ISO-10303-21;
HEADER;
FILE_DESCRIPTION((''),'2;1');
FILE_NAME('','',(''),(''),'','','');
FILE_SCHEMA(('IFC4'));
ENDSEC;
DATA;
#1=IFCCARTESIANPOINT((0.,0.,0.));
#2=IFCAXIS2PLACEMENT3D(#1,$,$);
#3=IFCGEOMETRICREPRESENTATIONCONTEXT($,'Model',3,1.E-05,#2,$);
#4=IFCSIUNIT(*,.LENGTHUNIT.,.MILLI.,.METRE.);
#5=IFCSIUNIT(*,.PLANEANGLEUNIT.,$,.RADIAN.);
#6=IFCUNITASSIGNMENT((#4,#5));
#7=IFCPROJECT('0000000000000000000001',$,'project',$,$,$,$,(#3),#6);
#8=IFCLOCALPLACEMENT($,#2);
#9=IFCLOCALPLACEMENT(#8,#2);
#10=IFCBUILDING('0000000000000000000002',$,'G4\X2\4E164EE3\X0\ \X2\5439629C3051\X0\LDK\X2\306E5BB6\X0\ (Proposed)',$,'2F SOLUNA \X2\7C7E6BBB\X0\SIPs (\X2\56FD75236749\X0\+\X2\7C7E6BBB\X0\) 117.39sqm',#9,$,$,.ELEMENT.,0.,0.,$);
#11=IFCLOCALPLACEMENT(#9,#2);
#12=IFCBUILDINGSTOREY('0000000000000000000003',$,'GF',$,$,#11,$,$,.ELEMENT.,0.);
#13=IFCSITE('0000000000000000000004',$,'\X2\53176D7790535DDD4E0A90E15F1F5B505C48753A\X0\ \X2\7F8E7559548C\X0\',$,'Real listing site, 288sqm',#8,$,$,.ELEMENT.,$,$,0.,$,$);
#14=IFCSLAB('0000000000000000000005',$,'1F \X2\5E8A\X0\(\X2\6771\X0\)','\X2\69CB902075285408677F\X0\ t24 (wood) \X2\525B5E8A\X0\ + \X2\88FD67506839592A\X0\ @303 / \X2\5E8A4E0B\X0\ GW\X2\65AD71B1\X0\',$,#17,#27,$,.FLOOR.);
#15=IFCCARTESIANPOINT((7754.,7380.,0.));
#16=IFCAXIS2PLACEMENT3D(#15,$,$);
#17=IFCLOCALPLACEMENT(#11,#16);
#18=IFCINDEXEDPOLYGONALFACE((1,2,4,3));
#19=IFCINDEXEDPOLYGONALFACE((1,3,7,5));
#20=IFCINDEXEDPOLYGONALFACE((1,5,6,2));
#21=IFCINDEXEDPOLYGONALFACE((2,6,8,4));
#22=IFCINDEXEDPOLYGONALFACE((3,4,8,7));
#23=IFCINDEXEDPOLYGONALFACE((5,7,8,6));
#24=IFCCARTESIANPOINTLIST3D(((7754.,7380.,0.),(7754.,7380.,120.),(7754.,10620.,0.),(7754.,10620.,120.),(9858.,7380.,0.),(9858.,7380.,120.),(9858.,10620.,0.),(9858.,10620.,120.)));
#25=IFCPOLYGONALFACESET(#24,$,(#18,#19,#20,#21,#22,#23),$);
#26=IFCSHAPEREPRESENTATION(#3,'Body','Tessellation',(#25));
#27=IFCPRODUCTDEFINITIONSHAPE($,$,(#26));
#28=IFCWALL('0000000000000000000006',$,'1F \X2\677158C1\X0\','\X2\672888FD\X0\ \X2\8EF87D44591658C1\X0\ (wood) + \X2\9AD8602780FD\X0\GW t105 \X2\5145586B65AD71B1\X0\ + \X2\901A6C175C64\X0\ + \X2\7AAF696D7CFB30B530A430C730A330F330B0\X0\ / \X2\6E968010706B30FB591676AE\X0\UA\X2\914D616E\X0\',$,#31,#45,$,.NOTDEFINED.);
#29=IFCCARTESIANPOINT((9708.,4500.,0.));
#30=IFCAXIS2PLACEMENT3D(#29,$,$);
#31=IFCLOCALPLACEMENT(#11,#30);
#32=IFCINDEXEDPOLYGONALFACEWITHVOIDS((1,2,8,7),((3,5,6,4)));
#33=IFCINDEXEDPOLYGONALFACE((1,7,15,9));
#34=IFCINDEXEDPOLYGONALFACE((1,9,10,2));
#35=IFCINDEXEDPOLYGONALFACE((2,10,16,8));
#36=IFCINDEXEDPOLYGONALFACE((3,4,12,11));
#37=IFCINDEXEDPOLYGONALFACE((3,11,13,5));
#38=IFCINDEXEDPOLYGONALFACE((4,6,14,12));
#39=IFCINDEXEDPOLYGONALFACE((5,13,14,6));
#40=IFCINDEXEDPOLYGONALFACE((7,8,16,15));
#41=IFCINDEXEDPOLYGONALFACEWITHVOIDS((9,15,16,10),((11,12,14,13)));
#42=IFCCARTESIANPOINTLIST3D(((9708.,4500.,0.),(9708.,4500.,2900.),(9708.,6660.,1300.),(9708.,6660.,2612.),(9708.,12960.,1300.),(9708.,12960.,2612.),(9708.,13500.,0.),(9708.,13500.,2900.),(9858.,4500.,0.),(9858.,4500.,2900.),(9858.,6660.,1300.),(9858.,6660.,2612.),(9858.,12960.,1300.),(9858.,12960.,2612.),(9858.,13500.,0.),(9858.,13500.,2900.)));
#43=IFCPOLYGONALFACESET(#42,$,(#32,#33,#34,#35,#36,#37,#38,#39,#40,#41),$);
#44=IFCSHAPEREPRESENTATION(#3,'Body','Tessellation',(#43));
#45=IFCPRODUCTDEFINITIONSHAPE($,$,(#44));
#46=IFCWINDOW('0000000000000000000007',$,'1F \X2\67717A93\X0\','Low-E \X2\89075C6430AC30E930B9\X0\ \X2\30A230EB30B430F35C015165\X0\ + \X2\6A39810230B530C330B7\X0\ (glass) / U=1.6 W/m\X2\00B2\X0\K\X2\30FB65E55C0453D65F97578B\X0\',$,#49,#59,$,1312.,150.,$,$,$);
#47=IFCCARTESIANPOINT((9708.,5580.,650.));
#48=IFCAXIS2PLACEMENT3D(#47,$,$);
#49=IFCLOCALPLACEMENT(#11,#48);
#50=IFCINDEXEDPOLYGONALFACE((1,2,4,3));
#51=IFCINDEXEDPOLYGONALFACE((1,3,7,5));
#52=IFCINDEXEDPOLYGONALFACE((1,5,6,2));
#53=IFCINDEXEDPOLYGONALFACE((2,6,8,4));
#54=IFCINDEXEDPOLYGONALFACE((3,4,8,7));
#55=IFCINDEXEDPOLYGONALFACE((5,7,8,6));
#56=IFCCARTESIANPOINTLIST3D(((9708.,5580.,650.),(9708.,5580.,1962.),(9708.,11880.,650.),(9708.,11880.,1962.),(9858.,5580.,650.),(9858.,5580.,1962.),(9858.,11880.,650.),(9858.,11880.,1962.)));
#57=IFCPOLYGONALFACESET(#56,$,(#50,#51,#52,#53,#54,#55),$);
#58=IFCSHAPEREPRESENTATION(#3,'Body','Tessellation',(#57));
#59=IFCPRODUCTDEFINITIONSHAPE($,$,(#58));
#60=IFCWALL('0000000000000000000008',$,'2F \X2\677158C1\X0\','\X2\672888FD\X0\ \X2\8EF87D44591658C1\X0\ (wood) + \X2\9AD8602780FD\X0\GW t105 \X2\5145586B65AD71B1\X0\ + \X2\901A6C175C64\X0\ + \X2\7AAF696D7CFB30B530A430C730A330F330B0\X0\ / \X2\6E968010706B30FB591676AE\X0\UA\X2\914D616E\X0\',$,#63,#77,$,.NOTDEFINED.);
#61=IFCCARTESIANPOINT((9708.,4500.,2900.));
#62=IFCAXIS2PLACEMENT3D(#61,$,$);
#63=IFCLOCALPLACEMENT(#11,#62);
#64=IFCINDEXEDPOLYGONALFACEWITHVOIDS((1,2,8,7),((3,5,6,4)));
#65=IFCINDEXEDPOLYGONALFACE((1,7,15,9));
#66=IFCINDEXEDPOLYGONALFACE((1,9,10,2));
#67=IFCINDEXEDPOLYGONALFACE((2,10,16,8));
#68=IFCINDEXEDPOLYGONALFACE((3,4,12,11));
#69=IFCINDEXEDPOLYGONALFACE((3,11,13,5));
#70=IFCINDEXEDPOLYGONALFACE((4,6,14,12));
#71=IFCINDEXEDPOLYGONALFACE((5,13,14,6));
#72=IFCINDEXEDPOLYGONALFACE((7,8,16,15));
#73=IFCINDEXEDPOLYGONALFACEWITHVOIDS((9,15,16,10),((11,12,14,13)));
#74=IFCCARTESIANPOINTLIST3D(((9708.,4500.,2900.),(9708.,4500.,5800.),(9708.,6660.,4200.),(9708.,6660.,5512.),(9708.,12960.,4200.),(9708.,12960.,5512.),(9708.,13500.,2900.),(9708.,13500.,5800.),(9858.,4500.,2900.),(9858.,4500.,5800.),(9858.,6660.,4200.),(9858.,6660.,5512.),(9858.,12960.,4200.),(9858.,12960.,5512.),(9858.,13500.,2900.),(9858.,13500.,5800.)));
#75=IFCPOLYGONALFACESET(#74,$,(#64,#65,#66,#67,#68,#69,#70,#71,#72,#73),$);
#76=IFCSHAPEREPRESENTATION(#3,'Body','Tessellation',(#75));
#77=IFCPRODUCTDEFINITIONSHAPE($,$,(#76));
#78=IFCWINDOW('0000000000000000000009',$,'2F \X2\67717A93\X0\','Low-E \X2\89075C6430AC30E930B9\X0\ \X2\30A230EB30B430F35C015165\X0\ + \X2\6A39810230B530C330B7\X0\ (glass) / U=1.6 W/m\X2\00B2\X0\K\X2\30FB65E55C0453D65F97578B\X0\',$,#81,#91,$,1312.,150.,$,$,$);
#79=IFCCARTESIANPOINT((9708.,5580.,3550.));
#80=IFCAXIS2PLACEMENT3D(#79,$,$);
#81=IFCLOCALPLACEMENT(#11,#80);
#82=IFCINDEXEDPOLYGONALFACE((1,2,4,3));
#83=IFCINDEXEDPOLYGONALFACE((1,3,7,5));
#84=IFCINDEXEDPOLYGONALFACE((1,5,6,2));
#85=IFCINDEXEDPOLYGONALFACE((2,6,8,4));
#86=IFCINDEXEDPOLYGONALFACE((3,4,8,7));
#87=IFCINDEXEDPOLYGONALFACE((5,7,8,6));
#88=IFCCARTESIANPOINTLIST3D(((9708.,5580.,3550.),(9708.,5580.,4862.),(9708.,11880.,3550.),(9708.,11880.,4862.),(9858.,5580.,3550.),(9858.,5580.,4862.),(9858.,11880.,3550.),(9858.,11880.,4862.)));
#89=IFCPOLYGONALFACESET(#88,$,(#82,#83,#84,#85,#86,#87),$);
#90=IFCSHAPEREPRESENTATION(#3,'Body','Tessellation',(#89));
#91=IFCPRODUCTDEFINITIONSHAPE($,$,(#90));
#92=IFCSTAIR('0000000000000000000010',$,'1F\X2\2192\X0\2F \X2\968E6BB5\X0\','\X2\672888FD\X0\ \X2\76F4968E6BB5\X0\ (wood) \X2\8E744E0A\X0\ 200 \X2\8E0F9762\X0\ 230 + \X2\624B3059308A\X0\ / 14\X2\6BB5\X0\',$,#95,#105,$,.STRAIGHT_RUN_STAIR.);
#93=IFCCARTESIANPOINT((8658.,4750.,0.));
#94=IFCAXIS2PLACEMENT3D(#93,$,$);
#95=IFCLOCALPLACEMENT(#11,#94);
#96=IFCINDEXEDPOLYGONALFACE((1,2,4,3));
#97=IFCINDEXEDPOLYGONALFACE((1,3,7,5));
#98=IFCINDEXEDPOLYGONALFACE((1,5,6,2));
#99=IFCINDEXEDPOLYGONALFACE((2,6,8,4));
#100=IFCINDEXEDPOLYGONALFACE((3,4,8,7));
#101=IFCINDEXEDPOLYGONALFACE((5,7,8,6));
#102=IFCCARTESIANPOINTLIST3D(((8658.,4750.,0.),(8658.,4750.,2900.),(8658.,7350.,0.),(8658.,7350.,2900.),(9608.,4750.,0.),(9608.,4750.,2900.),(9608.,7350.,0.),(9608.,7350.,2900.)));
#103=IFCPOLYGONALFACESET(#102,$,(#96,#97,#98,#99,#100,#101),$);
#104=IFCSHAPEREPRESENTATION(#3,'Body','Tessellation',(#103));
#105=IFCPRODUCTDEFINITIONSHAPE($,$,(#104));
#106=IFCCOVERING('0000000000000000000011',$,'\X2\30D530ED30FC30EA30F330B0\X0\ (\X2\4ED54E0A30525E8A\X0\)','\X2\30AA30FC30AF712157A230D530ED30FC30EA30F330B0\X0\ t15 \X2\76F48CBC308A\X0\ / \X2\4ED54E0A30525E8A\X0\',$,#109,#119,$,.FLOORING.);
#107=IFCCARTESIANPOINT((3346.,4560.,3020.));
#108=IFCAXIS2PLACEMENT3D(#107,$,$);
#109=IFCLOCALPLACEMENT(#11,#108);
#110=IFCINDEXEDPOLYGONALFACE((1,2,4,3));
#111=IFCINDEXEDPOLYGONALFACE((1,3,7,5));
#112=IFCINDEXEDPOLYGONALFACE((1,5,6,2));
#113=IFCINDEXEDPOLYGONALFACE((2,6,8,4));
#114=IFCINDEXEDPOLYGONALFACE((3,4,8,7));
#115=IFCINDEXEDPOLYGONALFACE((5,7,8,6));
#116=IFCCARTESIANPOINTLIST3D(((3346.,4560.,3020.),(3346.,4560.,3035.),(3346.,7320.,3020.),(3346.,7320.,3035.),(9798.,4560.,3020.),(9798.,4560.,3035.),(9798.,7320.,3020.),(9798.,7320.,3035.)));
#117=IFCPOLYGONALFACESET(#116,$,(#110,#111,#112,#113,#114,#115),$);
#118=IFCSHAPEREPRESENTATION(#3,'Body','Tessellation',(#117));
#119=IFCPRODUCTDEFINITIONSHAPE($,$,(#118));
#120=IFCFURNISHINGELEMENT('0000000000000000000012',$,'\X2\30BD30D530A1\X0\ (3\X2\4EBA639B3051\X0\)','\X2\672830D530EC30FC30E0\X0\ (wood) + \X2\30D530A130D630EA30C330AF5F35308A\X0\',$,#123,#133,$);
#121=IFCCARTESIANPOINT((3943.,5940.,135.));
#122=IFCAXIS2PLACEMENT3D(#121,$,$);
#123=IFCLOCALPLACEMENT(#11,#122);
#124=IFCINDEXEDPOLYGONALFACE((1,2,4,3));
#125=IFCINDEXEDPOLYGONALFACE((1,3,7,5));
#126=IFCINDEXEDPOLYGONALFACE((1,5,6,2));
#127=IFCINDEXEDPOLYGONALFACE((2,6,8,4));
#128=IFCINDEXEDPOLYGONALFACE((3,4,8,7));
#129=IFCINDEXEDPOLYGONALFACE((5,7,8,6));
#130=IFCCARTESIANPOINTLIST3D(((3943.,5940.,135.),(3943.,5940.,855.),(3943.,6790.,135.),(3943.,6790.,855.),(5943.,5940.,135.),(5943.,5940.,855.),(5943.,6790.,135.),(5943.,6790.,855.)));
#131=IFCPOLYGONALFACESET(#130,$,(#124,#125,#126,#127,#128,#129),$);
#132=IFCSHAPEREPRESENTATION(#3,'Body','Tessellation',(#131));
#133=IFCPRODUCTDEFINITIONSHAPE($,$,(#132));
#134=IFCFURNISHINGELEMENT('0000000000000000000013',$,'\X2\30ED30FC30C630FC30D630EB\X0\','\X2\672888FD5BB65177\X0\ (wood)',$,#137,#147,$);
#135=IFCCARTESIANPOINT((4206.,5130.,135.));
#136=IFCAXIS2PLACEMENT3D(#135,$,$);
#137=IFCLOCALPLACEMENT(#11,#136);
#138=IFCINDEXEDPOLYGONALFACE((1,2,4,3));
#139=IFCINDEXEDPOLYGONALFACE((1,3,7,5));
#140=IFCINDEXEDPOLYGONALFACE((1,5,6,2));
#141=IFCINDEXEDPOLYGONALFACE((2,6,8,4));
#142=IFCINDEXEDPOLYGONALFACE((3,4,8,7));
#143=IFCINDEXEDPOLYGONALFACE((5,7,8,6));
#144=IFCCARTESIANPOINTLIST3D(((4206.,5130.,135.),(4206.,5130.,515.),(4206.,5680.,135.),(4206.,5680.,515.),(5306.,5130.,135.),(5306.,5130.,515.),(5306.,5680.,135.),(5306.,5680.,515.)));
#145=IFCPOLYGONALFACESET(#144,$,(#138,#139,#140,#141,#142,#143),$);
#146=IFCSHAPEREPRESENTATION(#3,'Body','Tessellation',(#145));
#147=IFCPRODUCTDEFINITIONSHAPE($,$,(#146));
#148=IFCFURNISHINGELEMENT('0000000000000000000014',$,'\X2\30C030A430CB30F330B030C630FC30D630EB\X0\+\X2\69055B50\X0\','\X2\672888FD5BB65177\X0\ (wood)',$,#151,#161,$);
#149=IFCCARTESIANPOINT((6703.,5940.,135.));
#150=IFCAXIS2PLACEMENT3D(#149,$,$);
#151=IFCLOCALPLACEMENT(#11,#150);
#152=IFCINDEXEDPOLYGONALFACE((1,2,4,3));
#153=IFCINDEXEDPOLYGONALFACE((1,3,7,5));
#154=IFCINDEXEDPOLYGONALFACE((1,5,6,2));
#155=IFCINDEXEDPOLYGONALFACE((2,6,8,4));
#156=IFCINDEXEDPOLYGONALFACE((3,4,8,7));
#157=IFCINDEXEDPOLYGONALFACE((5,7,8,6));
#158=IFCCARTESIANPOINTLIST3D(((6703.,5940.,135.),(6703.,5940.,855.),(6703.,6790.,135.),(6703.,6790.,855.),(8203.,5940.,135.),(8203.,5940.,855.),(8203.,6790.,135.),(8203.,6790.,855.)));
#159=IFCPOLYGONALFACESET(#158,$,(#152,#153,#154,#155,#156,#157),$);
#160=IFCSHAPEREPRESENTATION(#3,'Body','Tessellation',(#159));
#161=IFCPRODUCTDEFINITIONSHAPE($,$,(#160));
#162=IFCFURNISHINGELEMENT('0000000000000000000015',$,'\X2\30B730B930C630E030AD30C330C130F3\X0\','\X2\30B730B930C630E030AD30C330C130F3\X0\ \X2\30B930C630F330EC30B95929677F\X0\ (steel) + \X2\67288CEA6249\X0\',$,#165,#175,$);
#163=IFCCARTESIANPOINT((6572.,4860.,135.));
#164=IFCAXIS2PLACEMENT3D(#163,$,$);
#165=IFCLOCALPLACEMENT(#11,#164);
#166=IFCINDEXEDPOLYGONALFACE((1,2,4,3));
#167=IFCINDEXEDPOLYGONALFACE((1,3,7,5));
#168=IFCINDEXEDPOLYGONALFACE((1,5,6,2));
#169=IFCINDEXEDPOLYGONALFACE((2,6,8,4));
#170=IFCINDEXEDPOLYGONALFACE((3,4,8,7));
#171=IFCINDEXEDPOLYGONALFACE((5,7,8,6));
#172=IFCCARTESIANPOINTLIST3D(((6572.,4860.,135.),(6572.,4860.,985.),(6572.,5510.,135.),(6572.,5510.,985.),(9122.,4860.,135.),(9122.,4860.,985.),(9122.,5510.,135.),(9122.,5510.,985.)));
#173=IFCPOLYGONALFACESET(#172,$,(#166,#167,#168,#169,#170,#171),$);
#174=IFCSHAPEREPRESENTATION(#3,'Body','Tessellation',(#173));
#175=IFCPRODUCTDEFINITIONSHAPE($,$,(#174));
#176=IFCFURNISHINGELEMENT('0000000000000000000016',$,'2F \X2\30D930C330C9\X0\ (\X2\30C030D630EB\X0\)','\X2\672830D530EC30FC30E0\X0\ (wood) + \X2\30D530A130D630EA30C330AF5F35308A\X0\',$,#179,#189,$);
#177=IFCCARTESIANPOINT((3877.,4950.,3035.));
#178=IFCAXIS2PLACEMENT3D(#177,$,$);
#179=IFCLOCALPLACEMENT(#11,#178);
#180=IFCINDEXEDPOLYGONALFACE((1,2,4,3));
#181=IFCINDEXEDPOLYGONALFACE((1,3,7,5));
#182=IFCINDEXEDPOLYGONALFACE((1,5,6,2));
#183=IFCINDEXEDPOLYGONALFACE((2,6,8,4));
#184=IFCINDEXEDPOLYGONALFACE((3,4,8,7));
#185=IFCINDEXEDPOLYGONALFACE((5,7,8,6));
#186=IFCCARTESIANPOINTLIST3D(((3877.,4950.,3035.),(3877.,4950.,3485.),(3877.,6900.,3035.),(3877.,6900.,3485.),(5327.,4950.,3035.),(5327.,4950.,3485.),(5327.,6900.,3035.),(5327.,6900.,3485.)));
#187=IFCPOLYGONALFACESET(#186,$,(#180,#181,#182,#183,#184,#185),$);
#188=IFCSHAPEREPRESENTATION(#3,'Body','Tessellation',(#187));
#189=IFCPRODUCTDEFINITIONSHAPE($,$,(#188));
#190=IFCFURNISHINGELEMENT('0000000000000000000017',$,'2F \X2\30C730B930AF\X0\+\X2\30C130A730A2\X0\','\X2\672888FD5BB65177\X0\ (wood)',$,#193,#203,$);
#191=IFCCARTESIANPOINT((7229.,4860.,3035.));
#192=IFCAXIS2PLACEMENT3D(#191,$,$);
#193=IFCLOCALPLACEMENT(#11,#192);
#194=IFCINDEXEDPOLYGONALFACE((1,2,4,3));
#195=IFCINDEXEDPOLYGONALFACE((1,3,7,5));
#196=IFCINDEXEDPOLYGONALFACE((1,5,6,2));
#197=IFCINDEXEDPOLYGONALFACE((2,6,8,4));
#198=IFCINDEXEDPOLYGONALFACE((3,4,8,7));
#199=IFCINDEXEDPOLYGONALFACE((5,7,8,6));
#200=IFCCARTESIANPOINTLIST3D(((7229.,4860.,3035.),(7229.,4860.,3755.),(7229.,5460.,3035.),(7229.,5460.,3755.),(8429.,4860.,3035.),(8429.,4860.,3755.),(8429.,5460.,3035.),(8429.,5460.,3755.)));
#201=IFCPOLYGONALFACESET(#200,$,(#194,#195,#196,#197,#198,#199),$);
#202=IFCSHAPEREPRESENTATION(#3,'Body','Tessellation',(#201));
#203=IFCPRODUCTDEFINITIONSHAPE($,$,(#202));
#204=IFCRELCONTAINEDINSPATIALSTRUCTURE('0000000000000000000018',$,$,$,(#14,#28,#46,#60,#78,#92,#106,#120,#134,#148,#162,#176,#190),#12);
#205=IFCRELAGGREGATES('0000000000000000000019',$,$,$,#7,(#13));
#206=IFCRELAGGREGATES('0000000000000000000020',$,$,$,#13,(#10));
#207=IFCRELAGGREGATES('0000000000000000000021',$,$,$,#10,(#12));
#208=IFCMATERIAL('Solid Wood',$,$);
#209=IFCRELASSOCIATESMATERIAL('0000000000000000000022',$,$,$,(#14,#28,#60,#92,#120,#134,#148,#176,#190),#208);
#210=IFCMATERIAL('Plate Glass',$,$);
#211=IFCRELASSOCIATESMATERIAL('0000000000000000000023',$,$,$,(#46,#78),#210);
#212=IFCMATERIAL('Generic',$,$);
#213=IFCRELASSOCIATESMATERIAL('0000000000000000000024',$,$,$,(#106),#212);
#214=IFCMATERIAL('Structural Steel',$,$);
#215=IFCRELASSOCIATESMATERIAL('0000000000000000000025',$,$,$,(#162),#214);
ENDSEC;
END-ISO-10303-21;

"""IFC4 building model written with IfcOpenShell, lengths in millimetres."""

from ifc_helpers import new_model, si_unit, frame, frame_2d, origin, place, context, project, spatial, rectangle, extrude, material, element, fill, save


model = new_model("IFC4")

# Units and contexts
model_context = context("Model", 3, precision=1e-05, world=origin())
ifc_project = project(units=[si_unit("LENGTHUNIT", "METRE", prefix="MILLI"), si_unit("PLANEANGLEUNIT", "RADIAN")], contexts=[model_context])

# Site, building, storey
site_placement = place(None, origin())
site = spatial("IfcSite", under=ifc_project, at=site_placement, Name="北海道川上郡弟子屈町 美留和", ObjectType="Real listing site, 288sqm", CompositionType="ELEMENT", RefElevation=0.0)
building_placement = place(site_placement, origin())
building = spatial("IfcBuilding", under=site, at=building_placement, Name="G4世代 吹抜けLDKの家 (Proposed)", ObjectType="2F SOLUNA 籾殻SIPs (国産杉+籾殻) 117.39sqm", CompositionType="ELEMENT", ElevationOfRefHeight=0.0, ElevationOfTerrain=0.0)
storey_placement = place(building_placement, origin())
storey = spatial("IfcBuildingStorey", under=building, at=storey_placement, Name="GF", CompositionType="ELEMENT", Elevation=0.0)

# Slab
ifc_material_1 = material(Name="Solid Wood")
slab_placement = place(storey_placement, frame((7754.0, 7380.0, 0.0)))
element("IfcSlab", 1, at=slab_placement, inside=storey, material=ifc_material_1, Name="1F 床(東)", Description="構造用合板 t24 (wood) 剛床 + 製材根太 @303 / 床下 GW断熱", PredefinedType="FLOOR", context=model_context, shape_type="SweptSolid", body=[
    extrude(rectangle(XDim=2104.0, YDim=3240.0, at=frame_2d((1052.0, 1620.0))), frame((7754.0, 7380.0, 0.0)), (0.0, 0.0, 1.0), 120.0),
])

# Wall, opening, window
wall_1_placement = place(storey_placement, frame((9708.0, 4500.0, 0.0)))
wall_1 = element("IfcWall", 2, at=wall_1_placement, inside=storey, material=ifc_material_1, Name="1F 東壁", Description="木製 軸組外壁 (wood) + 高性能GW t105 充填断熱 + 通気層 + 窯業系サイディング / 準耐火・外皮UA配慮", PredefinedType="NOTDEFINED", context=model_context, shape_type="SweptSolid", body=[
    extrude(rectangle(XDim=150.0, YDim=9000.0, at=frame_2d((75.0, 4500.0))), frame((9708.0, 4500.0, 0.0)), (0.0, 0.0, 1.0), 2900.0),
])
opening_1_placement = place(storey_placement, frame((9708.0, 5580.0, 650.0)))
opening_1 = element("IfcOpeningElement", 3, at=opening_1_placement, cuts=wall_1, PredefinedType="NOTDEFINED", context=model_context, shape_type="SweptSolid", body=[
    extrude(rectangle(XDim=150.0, YDim=6300.0, at=frame_2d((75.0, 3150.0))), frame((9708.0, 5580.0, 650.0)), (0.0, 0.0, 1.0), 1312.0),
])
ifc_material_2 = material(Name="Plate Glass")
window_1_placement = place(storey_placement, frame((9708.0, 5580.0, 650.0)))
window_1 = element("IfcWindow", 4, at=window_1_placement, inside=storey, material=ifc_material_2, Name="1F 東窓", Description="Low-E 複層ガラス アルゴン封入 + 樹脂サッシ (glass) / U=1.6 W/m²K・日射取得型", OverallHeight=1312.0, OverallWidth=150.0, context=model_context, shape_type="SweptSolid", body=[
    extrude(rectangle(XDim=150.0, YDim=6300.0, at=frame_2d((75.0, 3150.0))), frame((9708.0, 5580.0, 650.0)), (0.0, 0.0, 1.0), 1312.0),
])
fill(opening_1, window_1)

# Wall, opening, window
wall_2_placement = place(storey_placement, frame((9708.0, 4500.0, 2900.0)))
wall_2 = element("IfcWall", 5, at=wall_2_placement, inside=storey, material=ifc_material_1, Name="2F 東壁", Description="木製 軸組外壁 (wood) + 高性能GW t105 充填断熱 + 通気層 + 窯業系サイディング / 準耐火・外皮UA配慮", PredefinedType="NOTDEFINED", context=model_context, shape_type="SweptSolid", body=[
    extrude(rectangle(XDim=150.0, YDim=9000.0, at=frame_2d((75.0, 4500.0))), frame((9708.0, 4500.0, 2900.0)), (0.0, 0.0, 1.0), 2900.0),
])
opening_2_placement = place(storey_placement, frame((9708.0, 5580.0, 3550.0)))
opening_2 = element("IfcOpeningElement", 6, at=opening_2_placement, cuts=wall_2, PredefinedType="NOTDEFINED", context=model_context, shape_type="SweptSolid", body=[
    extrude(rectangle(XDim=150.0, YDim=6300.0, at=frame_2d((75.0, 3150.0))), frame((9708.0, 5580.0, 3550.0)), (0.0, 0.0, 1.0), 1312.0),
])
window_2_placement = place(storey_placement, frame((9708.0, 5580.0, 3550.0)))
window_2 = element("IfcWindow", 7, at=window_2_placement, inside=storey, material=ifc_material_2, Name="2F 東窓", Description="Low-E 複層ガラス アルゴン封入 + 樹脂サッシ (glass) / U=1.6 W/m²K・日射取得型", OverallHeight=1312.0, OverallWidth=150.0, context=model_context, shape_type="SweptSolid", body=[
    extrude(rectangle(XDim=150.0, YDim=6300.0, at=frame_2d((75.0, 3150.0))), frame((9708.0, 5580.0, 3550.0)), (0.0, 0.0, 1.0), 1312.0),
])
fill(opening_2, window_2)

# Stair
stair_placement = place(storey_placement, frame((8658.0, 4750.0, 0.0)))
element("IfcStair", 8, at=stair_placement, inside=storey, material=ifc_material_1, Name="1F→2F 階段", Description="木製 直階段 (wood) 蹴上 200 踏面 230 + 手すり / 14段", PredefinedType="STRAIGHT_RUN_STAIR", context=model_context, shape_type="SweptSolid", body=[
    extrude(rectangle(XDim=950.0, YDim=2600.0, at=frame_2d((475.0, 1300.0))), frame((8658.0, 4750.0, 0.0)), (0.0, 0.0, 1.0), 2900.0),
])

# Covering
ifc_material_3 = material(Name="Generic")
covering_placement = place(storey_placement, frame((3346.0, 4560.0, 3020.0)))
element("IfcCovering", 9, at=covering_placement, inside=storey, material=ifc_material_3, Name="フローリング (仕上げ床)", Description="オーク無垢フローリング t15 直貼り / 仕上げ床", PredefinedType="FLOORING", context=model_context, shape_type="SweptSolid", body=[
    extrude(rectangle(XDim=6452.0, YDim=2760.0, at=frame_2d((3226.0, 1380.0))), frame((3346.0, 4560.0, 3020.0)), (0.0, 0.0, 1.0), 15.0),
])

# Furnishing elements
furnishing_1_placement = place(storey_placement, frame((3943.0, 5940.0, 135.0)))
element("IfcFurnishingElement", 10, at=furnishing_1_placement, inside=storey, material=ifc_material_1, Name="ソファ (3人掛け)", Description="木フレーム (wood) + ファブリック張り", context=model_context, shape_type="SweptSolid", body=[
    extrude(rectangle(XDim=2000.0, YDim=850.0, at=frame_2d((1000.0, 425.0))), frame((3943.0, 5940.0, 135.0)), (0.0, 0.0, 1.0), 720.0),
])
furnishing_2_placement = place(storey_placement, frame((4206.0, 5130.0, 135.0)))
element("IfcFurnishingElement", 11, at=furnishing_2_placement, inside=storey, material=ifc_material_1, Name="ローテーブル", Description="木製家具 (wood)", context=model_context, shape_type="SweptSolid", body=[
    extrude(rectangle(XDim=1100.0, YDim=550.0, at=frame_2d((550.0, 275.0))), frame((4206.0, 5130.0, 135.0)), (0.0, 0.0, 1.0), 380.0),
])
furnishing_3_placement = place(storey_placement, frame((6703.0, 5940.0, 135.0)))
element("IfcFurnishingElement", 12, at=furnishing_3_placement, inside=storey, material=ifc_material_1, Name="ダイニングテーブル+椅子", Description="木製家具 (wood)", context=model_context, shape_type="SweptSolid", body=[
    extrude(rectangle(XDim=1500.0, YDim=850.0, at=frame_2d((750.0, 425.0))), frame((6703.0, 5940.0, 135.0)), (0.0, 0.0, 1.0), 720.0),
])
ifc_material_4 = material(Name="Structural Steel")
furnishing_4_placement = place(storey_placement, frame((6572.0, 4860.0, 135.0)))
element("IfcFurnishingElement", 13, at=furnishing_4_placement, inside=storey, material=ifc_material_4, Name="システムキッチン", Description="システムキッチン ステンレス天板 (steel) + 木質扉", context=model_context, shape_type="SweptSolid", body=[
    extrude(rectangle(XDim=2550.0, YDim=650.0, at=frame_2d((1275.0, 325.0))), frame((6572.0, 4860.0, 135.0)), (0.0, 0.0, 1.0), 850.0),
])
furnishing_5_placement = place(storey_placement, frame((3877.0, 4950.0, 3035.0)))
element("IfcFurnishingElement", 14, at=furnishing_5_placement, inside=storey, material=ifc_material_1, Name="2F ベッド (ダブル)", Description="木フレーム (wood) + ファブリック張り", context=model_context, shape_type="SweptSolid", body=[
    extrude(rectangle(XDim=1450.0, YDim=1950.0, at=frame_2d((725.0, 975.0))), frame((3877.0, 4950.0, 3035.0)), (0.0, 0.0, 1.0), 450.0),
])
furnishing_6_placement = place(storey_placement, frame((7229.0, 4860.0, 3035.0)))
element("IfcFurnishingElement", 15, at=furnishing_6_placement, inside=storey, material=ifc_material_1, Name="2F デスク+チェア", Description="木製家具 (wood)", context=model_context, shape_type="SweptSolid", body=[
    extrude(rectangle(XDim=1200.0, YDim=600.0, at=frame_2d((600.0, 300.0))), frame((7229.0, 4860.0, 3035.0)), (0.0, 0.0, 1.0), 720.0),
])

save(model, "model.ifc")
